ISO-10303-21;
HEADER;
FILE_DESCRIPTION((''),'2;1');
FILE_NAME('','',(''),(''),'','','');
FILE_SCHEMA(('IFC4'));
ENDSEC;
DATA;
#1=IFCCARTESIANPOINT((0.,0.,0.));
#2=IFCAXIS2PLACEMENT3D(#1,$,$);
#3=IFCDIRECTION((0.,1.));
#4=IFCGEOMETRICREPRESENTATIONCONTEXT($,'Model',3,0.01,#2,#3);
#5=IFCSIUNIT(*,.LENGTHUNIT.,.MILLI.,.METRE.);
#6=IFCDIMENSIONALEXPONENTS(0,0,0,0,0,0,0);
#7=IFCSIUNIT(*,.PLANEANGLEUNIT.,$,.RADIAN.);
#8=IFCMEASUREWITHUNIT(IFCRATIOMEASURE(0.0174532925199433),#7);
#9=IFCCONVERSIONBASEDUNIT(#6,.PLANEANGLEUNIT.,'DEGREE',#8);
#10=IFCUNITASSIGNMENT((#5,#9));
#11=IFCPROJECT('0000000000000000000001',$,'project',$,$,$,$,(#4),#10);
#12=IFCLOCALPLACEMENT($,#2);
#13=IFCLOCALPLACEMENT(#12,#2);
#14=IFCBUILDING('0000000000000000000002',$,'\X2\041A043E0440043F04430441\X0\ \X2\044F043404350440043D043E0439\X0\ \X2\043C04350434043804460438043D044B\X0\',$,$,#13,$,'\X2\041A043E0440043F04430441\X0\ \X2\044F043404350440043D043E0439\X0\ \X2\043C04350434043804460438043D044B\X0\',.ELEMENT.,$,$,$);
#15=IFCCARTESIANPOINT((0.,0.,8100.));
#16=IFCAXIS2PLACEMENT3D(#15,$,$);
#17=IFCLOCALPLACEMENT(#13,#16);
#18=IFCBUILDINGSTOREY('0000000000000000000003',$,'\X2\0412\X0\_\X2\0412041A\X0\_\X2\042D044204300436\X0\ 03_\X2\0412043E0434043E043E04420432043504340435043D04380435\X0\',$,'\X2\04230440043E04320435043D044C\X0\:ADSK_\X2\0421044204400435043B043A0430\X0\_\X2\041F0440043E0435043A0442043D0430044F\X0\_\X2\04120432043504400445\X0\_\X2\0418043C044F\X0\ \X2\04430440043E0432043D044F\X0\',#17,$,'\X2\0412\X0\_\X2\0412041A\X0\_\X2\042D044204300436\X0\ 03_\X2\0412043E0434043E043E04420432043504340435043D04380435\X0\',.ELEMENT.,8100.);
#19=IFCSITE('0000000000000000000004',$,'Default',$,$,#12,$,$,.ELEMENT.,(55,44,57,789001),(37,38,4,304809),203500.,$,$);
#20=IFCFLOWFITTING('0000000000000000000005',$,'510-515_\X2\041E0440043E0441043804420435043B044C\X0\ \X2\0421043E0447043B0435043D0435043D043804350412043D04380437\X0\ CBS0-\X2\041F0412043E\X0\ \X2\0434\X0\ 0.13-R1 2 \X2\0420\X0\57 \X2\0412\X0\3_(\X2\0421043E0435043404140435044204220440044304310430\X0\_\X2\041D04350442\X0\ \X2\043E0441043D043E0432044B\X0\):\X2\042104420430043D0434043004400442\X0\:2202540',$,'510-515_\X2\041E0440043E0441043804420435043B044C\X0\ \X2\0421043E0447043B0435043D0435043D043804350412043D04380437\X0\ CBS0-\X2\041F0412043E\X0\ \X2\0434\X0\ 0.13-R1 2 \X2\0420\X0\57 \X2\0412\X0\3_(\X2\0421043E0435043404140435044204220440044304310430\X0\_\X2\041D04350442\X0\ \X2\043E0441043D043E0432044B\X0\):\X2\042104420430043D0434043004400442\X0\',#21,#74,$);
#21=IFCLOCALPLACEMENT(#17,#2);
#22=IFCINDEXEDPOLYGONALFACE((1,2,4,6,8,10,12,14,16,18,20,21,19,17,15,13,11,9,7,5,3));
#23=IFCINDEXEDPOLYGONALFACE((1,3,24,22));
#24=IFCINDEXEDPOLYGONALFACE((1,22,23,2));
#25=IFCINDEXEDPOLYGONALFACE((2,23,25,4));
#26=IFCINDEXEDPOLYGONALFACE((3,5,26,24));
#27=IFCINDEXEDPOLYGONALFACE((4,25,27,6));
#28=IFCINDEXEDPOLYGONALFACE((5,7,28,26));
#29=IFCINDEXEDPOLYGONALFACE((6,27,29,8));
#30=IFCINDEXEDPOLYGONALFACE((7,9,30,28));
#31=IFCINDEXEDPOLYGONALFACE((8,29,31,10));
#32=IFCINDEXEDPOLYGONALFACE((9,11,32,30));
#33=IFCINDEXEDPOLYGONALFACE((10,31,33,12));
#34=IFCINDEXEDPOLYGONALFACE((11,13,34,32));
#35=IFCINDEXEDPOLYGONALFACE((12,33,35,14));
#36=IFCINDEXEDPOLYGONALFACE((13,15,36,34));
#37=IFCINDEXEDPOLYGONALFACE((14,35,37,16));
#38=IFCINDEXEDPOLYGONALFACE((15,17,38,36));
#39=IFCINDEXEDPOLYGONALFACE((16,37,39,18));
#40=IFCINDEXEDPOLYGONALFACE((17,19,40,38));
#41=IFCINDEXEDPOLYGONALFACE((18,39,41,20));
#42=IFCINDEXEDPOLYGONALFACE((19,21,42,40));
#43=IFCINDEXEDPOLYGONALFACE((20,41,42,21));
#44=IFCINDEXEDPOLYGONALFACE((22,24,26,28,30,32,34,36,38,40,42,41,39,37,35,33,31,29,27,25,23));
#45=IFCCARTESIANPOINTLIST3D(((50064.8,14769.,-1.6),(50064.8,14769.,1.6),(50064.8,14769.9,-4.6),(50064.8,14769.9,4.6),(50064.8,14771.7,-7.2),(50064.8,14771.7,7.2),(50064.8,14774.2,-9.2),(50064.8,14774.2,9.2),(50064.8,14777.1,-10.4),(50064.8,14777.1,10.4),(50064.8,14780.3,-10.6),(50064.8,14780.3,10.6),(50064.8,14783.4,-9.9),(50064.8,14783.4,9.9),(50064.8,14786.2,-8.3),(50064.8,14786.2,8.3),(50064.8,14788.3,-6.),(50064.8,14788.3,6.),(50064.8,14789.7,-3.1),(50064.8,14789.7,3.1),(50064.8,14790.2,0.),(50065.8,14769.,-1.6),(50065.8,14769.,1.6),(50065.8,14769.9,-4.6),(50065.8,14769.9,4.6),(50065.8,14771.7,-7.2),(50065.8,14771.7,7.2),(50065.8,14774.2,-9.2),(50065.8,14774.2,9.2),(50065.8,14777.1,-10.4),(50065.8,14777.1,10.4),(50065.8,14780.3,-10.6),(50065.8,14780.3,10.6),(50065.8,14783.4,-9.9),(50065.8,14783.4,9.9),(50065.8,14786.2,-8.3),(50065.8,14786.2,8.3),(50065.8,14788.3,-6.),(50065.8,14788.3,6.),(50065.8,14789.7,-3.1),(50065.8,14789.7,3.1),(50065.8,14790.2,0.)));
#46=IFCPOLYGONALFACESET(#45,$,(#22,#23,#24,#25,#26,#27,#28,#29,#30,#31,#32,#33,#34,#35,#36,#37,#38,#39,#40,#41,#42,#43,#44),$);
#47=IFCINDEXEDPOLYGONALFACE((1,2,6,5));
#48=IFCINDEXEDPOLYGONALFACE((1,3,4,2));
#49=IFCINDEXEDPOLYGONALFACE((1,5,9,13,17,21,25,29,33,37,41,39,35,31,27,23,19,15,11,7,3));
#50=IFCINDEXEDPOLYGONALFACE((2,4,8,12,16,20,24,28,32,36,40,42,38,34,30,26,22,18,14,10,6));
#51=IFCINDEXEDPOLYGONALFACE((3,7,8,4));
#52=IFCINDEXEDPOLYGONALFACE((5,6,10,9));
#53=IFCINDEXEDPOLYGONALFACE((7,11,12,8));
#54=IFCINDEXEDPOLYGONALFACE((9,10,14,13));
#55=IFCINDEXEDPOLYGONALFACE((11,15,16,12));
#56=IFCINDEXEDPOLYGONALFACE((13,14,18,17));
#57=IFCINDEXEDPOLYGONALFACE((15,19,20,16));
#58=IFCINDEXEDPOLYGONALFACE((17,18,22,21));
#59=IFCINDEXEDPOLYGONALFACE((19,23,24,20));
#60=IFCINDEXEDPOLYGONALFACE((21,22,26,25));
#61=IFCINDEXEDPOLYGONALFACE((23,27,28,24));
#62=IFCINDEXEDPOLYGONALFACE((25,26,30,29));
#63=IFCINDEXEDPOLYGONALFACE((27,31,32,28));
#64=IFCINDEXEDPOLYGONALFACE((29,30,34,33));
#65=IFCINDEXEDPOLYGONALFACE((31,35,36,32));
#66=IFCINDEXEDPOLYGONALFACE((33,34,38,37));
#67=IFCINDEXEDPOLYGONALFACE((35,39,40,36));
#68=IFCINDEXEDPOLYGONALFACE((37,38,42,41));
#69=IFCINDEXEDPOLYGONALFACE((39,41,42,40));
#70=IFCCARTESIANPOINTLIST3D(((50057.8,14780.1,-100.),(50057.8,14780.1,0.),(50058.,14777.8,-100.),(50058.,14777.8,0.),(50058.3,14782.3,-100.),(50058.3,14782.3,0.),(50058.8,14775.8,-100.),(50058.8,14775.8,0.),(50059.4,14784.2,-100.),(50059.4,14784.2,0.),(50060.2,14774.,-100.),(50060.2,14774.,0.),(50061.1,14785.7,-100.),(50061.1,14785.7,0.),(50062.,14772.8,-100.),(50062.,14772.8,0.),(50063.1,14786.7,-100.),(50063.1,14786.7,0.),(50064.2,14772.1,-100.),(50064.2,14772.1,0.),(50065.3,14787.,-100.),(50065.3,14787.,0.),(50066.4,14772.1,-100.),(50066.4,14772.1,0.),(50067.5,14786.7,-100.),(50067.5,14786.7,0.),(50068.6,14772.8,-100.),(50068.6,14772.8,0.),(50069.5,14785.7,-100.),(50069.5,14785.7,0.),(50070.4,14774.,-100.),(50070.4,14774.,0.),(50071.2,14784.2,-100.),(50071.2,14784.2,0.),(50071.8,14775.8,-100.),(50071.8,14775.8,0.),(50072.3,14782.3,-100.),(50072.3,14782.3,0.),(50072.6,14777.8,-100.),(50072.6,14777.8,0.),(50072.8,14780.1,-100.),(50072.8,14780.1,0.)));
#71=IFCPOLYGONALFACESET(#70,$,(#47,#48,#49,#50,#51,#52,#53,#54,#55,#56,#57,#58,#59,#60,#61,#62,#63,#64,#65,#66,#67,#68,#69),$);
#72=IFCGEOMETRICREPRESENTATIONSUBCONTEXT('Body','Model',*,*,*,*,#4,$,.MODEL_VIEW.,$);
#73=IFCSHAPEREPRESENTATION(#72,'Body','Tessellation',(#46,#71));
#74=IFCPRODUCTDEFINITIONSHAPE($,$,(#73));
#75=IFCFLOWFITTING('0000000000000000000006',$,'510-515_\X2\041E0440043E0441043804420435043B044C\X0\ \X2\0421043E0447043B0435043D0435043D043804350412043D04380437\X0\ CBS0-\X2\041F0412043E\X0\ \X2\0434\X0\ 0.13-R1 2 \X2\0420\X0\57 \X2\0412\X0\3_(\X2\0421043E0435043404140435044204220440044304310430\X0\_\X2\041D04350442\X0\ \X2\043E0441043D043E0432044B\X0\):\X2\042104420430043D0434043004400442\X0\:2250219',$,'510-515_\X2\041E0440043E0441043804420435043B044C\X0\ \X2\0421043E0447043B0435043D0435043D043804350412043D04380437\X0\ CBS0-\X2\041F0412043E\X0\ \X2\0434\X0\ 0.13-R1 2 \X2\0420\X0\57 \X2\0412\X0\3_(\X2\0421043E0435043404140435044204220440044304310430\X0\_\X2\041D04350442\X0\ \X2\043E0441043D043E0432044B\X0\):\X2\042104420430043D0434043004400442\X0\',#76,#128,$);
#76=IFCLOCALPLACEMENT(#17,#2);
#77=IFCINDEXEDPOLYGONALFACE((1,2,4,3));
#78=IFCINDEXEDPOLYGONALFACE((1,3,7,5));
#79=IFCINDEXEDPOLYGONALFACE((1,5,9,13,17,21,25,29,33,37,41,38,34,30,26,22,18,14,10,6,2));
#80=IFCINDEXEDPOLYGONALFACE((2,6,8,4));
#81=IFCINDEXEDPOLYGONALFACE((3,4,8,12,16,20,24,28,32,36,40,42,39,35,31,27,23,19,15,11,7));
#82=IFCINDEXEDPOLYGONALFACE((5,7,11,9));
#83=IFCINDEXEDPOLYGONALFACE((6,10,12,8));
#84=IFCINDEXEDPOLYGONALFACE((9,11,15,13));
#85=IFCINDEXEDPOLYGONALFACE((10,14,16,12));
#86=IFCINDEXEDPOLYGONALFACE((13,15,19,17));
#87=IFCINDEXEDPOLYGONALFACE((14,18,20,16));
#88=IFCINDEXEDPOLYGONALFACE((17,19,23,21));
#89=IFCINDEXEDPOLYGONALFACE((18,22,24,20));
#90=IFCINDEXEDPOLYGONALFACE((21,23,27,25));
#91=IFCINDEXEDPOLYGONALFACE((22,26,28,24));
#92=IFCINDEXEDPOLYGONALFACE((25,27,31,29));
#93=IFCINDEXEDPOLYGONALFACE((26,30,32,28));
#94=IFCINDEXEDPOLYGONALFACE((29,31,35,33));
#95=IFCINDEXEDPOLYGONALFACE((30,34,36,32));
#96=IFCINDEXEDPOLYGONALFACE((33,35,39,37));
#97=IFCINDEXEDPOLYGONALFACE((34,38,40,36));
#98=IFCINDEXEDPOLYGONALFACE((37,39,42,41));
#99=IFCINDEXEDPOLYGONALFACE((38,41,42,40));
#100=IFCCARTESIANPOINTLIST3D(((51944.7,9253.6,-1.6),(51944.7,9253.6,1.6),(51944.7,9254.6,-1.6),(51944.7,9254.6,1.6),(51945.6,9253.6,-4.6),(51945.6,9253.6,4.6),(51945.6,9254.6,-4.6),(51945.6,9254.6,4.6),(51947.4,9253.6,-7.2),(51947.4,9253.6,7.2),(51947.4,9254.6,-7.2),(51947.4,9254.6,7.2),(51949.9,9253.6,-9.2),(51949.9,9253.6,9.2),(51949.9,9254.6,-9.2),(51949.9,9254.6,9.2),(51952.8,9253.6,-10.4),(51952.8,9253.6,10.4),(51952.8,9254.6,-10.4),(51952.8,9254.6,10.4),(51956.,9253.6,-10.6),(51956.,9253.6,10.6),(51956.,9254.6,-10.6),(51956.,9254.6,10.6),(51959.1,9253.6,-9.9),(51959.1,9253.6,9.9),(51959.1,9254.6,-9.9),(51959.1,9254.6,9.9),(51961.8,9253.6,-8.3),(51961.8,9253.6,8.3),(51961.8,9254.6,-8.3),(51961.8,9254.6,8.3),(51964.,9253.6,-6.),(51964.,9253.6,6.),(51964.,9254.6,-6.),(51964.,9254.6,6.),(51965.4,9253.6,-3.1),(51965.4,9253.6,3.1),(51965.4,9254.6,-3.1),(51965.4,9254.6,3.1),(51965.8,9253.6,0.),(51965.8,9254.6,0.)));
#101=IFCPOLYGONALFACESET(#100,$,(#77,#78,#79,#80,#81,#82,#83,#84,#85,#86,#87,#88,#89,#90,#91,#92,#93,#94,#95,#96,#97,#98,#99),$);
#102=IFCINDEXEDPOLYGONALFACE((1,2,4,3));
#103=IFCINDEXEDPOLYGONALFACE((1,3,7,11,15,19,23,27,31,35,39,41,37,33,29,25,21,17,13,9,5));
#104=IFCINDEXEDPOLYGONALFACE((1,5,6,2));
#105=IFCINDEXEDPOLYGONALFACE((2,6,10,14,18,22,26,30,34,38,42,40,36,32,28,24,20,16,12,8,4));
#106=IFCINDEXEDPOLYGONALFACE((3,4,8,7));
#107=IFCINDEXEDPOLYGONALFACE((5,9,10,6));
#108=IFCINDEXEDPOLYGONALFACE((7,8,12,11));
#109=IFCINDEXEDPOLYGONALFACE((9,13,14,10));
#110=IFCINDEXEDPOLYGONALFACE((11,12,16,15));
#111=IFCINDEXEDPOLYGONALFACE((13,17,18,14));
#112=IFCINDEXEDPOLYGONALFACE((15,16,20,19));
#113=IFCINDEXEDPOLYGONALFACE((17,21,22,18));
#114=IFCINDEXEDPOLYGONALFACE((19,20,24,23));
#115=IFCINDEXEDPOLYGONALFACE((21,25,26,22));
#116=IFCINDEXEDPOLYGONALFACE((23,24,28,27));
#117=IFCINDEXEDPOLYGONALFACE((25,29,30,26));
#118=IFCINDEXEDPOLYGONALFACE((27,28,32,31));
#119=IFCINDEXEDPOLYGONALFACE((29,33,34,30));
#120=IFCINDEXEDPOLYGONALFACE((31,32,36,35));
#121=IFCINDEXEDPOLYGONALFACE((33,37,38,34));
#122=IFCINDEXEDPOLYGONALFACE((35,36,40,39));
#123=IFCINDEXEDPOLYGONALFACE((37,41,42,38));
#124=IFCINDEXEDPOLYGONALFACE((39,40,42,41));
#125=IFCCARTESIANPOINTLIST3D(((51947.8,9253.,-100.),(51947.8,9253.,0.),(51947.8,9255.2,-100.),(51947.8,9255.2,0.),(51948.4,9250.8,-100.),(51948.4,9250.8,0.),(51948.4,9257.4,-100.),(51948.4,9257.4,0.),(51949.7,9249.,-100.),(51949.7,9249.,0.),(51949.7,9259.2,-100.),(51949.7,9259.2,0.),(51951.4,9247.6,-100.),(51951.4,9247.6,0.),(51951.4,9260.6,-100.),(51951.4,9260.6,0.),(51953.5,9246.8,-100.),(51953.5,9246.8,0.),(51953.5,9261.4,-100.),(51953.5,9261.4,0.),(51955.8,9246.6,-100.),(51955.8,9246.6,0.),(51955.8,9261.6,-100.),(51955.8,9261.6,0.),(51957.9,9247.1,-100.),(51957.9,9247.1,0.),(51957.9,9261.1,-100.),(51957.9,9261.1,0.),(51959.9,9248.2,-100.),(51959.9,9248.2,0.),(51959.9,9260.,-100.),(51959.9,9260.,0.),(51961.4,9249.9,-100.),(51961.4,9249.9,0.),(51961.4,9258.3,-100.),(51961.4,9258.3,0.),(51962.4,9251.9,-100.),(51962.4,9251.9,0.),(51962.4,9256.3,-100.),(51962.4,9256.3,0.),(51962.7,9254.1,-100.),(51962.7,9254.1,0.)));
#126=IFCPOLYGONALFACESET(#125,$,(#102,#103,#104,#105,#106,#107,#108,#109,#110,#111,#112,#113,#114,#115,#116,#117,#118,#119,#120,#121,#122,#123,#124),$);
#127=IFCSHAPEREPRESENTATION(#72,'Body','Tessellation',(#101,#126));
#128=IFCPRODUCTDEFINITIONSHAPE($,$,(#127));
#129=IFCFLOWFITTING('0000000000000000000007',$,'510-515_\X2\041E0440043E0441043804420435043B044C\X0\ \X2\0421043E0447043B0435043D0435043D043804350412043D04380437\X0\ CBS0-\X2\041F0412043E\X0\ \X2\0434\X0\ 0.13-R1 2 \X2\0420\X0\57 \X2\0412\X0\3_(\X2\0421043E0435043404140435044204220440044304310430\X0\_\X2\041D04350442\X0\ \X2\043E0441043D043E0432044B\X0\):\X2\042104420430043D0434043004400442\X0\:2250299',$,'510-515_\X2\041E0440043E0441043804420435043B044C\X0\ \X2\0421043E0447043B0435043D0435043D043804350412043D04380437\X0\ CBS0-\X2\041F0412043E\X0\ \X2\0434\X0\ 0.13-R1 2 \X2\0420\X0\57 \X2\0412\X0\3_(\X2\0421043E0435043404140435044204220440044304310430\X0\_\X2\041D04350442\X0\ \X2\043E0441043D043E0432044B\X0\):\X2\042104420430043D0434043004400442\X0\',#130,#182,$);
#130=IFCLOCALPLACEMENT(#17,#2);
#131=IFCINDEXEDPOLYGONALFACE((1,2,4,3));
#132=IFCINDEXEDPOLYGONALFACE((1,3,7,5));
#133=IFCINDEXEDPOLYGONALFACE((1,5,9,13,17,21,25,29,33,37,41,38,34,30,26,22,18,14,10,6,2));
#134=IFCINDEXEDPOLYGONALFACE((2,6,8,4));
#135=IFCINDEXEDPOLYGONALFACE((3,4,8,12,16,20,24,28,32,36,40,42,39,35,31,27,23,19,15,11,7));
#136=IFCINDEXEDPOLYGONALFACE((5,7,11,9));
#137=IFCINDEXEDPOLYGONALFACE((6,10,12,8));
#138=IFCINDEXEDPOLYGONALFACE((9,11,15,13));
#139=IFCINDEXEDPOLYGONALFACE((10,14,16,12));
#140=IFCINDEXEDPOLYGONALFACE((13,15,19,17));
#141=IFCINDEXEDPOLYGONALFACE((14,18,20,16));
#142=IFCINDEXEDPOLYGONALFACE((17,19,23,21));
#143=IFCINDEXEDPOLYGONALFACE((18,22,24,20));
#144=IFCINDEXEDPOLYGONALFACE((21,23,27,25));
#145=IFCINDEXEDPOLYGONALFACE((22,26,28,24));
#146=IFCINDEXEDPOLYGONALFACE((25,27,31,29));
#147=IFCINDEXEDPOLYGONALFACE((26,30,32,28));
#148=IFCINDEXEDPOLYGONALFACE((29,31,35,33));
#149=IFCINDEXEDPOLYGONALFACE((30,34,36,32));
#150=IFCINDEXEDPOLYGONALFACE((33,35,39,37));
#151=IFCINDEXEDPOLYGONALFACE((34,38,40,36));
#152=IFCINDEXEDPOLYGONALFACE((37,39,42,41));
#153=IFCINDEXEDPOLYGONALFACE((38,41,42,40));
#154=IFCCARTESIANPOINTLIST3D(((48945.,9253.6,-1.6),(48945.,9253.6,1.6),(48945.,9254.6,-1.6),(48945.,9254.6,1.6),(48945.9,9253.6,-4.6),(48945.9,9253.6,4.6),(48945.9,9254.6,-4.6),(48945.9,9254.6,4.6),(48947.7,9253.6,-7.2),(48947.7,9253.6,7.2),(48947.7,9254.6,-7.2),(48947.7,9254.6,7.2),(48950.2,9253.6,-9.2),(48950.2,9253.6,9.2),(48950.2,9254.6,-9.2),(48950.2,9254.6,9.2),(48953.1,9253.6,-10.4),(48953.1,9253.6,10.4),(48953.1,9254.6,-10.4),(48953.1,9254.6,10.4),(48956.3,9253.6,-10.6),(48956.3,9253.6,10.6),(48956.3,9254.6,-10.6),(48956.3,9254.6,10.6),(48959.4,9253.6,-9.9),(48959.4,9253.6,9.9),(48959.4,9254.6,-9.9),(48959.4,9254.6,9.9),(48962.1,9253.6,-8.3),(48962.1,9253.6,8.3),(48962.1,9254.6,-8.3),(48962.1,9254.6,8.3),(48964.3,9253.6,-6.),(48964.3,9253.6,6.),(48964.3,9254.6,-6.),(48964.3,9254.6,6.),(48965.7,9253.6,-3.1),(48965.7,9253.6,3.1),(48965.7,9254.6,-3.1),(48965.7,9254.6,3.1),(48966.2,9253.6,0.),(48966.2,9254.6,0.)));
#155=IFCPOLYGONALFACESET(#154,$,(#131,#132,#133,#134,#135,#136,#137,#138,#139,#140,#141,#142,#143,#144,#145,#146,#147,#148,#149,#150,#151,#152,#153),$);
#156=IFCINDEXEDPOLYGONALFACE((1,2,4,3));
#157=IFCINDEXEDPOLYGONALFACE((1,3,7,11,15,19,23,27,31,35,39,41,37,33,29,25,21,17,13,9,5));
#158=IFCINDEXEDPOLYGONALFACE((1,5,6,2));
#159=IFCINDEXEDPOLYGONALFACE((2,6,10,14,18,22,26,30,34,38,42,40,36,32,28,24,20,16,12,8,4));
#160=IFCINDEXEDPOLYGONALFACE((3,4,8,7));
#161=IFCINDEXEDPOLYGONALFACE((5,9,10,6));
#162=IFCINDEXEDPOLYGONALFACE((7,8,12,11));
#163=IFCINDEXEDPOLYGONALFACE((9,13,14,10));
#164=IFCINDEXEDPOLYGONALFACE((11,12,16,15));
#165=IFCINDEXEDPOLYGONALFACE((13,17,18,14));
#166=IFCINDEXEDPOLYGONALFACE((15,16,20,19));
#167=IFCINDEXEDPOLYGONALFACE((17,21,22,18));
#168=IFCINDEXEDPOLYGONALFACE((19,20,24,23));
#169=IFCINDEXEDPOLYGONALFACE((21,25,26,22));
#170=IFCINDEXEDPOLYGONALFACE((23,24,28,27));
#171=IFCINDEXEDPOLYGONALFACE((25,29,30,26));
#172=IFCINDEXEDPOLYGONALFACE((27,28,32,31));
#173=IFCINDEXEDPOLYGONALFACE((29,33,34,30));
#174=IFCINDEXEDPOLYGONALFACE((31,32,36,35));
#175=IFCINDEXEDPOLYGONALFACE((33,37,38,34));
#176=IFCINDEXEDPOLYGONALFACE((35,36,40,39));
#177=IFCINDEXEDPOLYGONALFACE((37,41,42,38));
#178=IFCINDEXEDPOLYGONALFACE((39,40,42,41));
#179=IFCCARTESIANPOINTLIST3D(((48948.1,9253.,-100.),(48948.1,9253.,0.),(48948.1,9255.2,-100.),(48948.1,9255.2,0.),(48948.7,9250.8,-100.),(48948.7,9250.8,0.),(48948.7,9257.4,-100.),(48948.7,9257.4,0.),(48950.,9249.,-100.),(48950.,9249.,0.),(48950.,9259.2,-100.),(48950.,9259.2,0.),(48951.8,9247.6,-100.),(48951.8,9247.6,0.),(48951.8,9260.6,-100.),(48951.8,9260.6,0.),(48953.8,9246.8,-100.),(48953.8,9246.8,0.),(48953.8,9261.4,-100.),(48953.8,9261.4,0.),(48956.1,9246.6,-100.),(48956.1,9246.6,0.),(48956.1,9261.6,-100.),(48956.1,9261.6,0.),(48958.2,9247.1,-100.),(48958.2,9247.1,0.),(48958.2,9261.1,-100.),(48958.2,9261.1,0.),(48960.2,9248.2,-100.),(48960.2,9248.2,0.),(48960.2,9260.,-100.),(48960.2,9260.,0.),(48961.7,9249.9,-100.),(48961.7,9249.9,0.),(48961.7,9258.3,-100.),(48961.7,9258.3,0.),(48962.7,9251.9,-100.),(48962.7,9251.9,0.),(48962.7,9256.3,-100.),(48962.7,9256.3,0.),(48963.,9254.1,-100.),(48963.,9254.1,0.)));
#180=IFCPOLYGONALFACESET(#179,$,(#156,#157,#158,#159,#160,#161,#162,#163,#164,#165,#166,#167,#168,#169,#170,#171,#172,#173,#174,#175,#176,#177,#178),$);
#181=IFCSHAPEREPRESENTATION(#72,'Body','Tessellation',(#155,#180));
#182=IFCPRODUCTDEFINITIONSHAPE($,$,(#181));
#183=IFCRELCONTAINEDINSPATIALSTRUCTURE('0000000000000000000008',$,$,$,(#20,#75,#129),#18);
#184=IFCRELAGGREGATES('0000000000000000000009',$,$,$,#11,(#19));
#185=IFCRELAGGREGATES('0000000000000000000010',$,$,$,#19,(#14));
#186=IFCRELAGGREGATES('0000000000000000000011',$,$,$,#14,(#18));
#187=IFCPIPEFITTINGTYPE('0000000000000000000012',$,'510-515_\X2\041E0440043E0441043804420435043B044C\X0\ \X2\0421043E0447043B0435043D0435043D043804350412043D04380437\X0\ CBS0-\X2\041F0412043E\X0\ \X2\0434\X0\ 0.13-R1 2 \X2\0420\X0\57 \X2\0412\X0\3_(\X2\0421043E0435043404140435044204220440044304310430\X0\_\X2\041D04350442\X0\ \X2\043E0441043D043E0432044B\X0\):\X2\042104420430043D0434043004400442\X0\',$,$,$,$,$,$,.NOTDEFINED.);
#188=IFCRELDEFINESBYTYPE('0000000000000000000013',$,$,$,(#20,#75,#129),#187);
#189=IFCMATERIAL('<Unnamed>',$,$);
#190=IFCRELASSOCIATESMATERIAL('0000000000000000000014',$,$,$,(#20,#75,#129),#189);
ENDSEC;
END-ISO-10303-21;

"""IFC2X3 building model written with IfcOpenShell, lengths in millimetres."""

from ifc_helpers import new_model, entity, si_unit, converted_unit, direction, frame, origin, origin_2d_with_axis, place, context, subcontext, project, spatial, circle, extrude, source, transform, mapped, material, type_object, type_shapes, element, save


model = new_model("IFC2X3")

# Units and contexts
model_context = context("Model", 3, precision=0.01, world=origin(), true_north=direction((0.0, 1.0)))
body_context = subcontext(model_context, "Body", "Model", "MODEL_VIEW")
ifc_project = project(units=[si_unit("LENGTHUNIT", "METRE", prefix="MILLI"), converted_unit("PLANEANGLEUNIT", "DEGREE", entity("IfcRatioMeasure", 0.0174532925199433), si_unit("PLANEANGLEUNIT", "RADIAN"), dimensions=[0, 0, 0, 0, 0, 0, 0])], contexts=[model_context])

# Site, building, storey
site_placement = place(None, origin())
site = spatial("IfcSite", under=ifc_project, at=site_placement, Name="Default", CompositionType="ELEMENT", RefLatitude=(55, 44, 57, 789001), RefLongitude=(37, 38, 4, 304809), RefElevation=203500.0)
building_placement = place(site_placement, origin())
building = spatial("IfcBuilding", under=site, at=building_placement, Name="Корпус ядерной медицины", LongName="Корпус ядерной медицины", CompositionType="ELEMENT")
storey_placement = place(building_placement, frame((0.0, 0.0, 8100.0)))
storey = spatial("IfcBuildingStorey", under=building, at=storey_placement, Name="В_ВК_Этаж 03_Водоотведение", ObjectType="Уровень:ADSK_Стрелка_Проектная_Вверх_Имя уровня", LongName="В_ВК_Этаж 03_Водоотведение", CompositionType="ELEMENT", Elevation=8100.0)

# Flow fittings
ifc_material_1 = material(Name="<Unnamed>")
pipe_fitting_type = type_object("IfcPipeFittingType", Name="510-515_Ороситель СочленениеВниз CBS0-ПВо д 0.13-R1 2 Р57 В3_(СоедДетТруба_Нет основы):Стандарт", PredefinedType="NOTDEFINED")
shared_shape_1 = source(origin(), body_context, "Body", "SweptSolid", [
    extrude(circle(Radius=10.7, at=origin_2d_with_axis()), frame((-0.5, 0.0, 0.0), z_axis=(1.0, 0.0, 0.0), x_axis=(0.0, 1.0, 0.0)), (0.0, 0.0, 1.0), 1.0),
    extrude(circle(Radius=7.5, at=origin_2d_with_axis()), frame((0.0, 0.0, -100.0), z_axis=(0.0, 0.0, 1.0), x_axis=(0.0, 1.0, 0.0)), (0.0, 0.0, 1.0), 100.0),
])
type_shapes(pipe_fitting_type, [shared_shape_1])
for number, where, name in (
    (1, (50065.3, 14779.5, 0.0), "510-515_Ороситель СочленениеВниз CBS0-ПВо д 0.13-R1 2 Р57 В3_(СоедДетТруба_Нет основы):Стандарт:2202540"),
):
    element("IfcFlowFitting", number, at=place(storey_placement, frame(where)), inside=storey, type_object=pipe_fitting_type, material=ifc_material_1, Name=name, ObjectType="510-515_Ороситель СочленениеВниз CBS0-ПВо д 0.13-R1 2 Р57 В3_(СоедДетТруба_Нет основы):Стандарт", context=body_context, shape_type="MappedRepresentation", body=[
        mapped(shared_shape_1, transform((0.0, 0.0, 0.0), scale=1.0)),
    ])
for number, where, z_axis, x_axis, name in (
    (2, (51955.2, 9254.1, 0.0), (0.0, 0.0, 1.0), (0.0, -1.0, 0.0), "510-515_Ороситель СочленениеВниз CBS0-ПВо д 0.13-R1 2 Р57 В3_(СоедДетТруба_Нет основы):Стандарт:2250219"),
    (3, (48955.5, 9254.1, 0.0), (0.0, 0.0, 1.0), (0.0, -1.0, 0.0), "510-515_Ороситель СочленениеВниз CBS0-ПВо д 0.13-R1 2 Р57 В3_(СоедДетТруба_Нет основы):Стандарт:2250299"),
):
    element("IfcFlowFitting", number, at=place(storey_placement, frame(where, z_axis=z_axis, x_axis=x_axis)), inside=storey, type_object=pipe_fitting_type, material=ifc_material_1, Name=name, ObjectType="510-515_Ороситель СочленениеВниз CBS0-ПВо д 0.13-R1 2 Р57 В3_(СоедДетТруба_Нет основы):Стандарт", context=body_context, shape_type="MappedRepresentation", body=[
        mapped(shared_shape_1, transform((0.0, 0.0, 0.0), scale=1.0)),
    ])

save(model, "model.ifc")
